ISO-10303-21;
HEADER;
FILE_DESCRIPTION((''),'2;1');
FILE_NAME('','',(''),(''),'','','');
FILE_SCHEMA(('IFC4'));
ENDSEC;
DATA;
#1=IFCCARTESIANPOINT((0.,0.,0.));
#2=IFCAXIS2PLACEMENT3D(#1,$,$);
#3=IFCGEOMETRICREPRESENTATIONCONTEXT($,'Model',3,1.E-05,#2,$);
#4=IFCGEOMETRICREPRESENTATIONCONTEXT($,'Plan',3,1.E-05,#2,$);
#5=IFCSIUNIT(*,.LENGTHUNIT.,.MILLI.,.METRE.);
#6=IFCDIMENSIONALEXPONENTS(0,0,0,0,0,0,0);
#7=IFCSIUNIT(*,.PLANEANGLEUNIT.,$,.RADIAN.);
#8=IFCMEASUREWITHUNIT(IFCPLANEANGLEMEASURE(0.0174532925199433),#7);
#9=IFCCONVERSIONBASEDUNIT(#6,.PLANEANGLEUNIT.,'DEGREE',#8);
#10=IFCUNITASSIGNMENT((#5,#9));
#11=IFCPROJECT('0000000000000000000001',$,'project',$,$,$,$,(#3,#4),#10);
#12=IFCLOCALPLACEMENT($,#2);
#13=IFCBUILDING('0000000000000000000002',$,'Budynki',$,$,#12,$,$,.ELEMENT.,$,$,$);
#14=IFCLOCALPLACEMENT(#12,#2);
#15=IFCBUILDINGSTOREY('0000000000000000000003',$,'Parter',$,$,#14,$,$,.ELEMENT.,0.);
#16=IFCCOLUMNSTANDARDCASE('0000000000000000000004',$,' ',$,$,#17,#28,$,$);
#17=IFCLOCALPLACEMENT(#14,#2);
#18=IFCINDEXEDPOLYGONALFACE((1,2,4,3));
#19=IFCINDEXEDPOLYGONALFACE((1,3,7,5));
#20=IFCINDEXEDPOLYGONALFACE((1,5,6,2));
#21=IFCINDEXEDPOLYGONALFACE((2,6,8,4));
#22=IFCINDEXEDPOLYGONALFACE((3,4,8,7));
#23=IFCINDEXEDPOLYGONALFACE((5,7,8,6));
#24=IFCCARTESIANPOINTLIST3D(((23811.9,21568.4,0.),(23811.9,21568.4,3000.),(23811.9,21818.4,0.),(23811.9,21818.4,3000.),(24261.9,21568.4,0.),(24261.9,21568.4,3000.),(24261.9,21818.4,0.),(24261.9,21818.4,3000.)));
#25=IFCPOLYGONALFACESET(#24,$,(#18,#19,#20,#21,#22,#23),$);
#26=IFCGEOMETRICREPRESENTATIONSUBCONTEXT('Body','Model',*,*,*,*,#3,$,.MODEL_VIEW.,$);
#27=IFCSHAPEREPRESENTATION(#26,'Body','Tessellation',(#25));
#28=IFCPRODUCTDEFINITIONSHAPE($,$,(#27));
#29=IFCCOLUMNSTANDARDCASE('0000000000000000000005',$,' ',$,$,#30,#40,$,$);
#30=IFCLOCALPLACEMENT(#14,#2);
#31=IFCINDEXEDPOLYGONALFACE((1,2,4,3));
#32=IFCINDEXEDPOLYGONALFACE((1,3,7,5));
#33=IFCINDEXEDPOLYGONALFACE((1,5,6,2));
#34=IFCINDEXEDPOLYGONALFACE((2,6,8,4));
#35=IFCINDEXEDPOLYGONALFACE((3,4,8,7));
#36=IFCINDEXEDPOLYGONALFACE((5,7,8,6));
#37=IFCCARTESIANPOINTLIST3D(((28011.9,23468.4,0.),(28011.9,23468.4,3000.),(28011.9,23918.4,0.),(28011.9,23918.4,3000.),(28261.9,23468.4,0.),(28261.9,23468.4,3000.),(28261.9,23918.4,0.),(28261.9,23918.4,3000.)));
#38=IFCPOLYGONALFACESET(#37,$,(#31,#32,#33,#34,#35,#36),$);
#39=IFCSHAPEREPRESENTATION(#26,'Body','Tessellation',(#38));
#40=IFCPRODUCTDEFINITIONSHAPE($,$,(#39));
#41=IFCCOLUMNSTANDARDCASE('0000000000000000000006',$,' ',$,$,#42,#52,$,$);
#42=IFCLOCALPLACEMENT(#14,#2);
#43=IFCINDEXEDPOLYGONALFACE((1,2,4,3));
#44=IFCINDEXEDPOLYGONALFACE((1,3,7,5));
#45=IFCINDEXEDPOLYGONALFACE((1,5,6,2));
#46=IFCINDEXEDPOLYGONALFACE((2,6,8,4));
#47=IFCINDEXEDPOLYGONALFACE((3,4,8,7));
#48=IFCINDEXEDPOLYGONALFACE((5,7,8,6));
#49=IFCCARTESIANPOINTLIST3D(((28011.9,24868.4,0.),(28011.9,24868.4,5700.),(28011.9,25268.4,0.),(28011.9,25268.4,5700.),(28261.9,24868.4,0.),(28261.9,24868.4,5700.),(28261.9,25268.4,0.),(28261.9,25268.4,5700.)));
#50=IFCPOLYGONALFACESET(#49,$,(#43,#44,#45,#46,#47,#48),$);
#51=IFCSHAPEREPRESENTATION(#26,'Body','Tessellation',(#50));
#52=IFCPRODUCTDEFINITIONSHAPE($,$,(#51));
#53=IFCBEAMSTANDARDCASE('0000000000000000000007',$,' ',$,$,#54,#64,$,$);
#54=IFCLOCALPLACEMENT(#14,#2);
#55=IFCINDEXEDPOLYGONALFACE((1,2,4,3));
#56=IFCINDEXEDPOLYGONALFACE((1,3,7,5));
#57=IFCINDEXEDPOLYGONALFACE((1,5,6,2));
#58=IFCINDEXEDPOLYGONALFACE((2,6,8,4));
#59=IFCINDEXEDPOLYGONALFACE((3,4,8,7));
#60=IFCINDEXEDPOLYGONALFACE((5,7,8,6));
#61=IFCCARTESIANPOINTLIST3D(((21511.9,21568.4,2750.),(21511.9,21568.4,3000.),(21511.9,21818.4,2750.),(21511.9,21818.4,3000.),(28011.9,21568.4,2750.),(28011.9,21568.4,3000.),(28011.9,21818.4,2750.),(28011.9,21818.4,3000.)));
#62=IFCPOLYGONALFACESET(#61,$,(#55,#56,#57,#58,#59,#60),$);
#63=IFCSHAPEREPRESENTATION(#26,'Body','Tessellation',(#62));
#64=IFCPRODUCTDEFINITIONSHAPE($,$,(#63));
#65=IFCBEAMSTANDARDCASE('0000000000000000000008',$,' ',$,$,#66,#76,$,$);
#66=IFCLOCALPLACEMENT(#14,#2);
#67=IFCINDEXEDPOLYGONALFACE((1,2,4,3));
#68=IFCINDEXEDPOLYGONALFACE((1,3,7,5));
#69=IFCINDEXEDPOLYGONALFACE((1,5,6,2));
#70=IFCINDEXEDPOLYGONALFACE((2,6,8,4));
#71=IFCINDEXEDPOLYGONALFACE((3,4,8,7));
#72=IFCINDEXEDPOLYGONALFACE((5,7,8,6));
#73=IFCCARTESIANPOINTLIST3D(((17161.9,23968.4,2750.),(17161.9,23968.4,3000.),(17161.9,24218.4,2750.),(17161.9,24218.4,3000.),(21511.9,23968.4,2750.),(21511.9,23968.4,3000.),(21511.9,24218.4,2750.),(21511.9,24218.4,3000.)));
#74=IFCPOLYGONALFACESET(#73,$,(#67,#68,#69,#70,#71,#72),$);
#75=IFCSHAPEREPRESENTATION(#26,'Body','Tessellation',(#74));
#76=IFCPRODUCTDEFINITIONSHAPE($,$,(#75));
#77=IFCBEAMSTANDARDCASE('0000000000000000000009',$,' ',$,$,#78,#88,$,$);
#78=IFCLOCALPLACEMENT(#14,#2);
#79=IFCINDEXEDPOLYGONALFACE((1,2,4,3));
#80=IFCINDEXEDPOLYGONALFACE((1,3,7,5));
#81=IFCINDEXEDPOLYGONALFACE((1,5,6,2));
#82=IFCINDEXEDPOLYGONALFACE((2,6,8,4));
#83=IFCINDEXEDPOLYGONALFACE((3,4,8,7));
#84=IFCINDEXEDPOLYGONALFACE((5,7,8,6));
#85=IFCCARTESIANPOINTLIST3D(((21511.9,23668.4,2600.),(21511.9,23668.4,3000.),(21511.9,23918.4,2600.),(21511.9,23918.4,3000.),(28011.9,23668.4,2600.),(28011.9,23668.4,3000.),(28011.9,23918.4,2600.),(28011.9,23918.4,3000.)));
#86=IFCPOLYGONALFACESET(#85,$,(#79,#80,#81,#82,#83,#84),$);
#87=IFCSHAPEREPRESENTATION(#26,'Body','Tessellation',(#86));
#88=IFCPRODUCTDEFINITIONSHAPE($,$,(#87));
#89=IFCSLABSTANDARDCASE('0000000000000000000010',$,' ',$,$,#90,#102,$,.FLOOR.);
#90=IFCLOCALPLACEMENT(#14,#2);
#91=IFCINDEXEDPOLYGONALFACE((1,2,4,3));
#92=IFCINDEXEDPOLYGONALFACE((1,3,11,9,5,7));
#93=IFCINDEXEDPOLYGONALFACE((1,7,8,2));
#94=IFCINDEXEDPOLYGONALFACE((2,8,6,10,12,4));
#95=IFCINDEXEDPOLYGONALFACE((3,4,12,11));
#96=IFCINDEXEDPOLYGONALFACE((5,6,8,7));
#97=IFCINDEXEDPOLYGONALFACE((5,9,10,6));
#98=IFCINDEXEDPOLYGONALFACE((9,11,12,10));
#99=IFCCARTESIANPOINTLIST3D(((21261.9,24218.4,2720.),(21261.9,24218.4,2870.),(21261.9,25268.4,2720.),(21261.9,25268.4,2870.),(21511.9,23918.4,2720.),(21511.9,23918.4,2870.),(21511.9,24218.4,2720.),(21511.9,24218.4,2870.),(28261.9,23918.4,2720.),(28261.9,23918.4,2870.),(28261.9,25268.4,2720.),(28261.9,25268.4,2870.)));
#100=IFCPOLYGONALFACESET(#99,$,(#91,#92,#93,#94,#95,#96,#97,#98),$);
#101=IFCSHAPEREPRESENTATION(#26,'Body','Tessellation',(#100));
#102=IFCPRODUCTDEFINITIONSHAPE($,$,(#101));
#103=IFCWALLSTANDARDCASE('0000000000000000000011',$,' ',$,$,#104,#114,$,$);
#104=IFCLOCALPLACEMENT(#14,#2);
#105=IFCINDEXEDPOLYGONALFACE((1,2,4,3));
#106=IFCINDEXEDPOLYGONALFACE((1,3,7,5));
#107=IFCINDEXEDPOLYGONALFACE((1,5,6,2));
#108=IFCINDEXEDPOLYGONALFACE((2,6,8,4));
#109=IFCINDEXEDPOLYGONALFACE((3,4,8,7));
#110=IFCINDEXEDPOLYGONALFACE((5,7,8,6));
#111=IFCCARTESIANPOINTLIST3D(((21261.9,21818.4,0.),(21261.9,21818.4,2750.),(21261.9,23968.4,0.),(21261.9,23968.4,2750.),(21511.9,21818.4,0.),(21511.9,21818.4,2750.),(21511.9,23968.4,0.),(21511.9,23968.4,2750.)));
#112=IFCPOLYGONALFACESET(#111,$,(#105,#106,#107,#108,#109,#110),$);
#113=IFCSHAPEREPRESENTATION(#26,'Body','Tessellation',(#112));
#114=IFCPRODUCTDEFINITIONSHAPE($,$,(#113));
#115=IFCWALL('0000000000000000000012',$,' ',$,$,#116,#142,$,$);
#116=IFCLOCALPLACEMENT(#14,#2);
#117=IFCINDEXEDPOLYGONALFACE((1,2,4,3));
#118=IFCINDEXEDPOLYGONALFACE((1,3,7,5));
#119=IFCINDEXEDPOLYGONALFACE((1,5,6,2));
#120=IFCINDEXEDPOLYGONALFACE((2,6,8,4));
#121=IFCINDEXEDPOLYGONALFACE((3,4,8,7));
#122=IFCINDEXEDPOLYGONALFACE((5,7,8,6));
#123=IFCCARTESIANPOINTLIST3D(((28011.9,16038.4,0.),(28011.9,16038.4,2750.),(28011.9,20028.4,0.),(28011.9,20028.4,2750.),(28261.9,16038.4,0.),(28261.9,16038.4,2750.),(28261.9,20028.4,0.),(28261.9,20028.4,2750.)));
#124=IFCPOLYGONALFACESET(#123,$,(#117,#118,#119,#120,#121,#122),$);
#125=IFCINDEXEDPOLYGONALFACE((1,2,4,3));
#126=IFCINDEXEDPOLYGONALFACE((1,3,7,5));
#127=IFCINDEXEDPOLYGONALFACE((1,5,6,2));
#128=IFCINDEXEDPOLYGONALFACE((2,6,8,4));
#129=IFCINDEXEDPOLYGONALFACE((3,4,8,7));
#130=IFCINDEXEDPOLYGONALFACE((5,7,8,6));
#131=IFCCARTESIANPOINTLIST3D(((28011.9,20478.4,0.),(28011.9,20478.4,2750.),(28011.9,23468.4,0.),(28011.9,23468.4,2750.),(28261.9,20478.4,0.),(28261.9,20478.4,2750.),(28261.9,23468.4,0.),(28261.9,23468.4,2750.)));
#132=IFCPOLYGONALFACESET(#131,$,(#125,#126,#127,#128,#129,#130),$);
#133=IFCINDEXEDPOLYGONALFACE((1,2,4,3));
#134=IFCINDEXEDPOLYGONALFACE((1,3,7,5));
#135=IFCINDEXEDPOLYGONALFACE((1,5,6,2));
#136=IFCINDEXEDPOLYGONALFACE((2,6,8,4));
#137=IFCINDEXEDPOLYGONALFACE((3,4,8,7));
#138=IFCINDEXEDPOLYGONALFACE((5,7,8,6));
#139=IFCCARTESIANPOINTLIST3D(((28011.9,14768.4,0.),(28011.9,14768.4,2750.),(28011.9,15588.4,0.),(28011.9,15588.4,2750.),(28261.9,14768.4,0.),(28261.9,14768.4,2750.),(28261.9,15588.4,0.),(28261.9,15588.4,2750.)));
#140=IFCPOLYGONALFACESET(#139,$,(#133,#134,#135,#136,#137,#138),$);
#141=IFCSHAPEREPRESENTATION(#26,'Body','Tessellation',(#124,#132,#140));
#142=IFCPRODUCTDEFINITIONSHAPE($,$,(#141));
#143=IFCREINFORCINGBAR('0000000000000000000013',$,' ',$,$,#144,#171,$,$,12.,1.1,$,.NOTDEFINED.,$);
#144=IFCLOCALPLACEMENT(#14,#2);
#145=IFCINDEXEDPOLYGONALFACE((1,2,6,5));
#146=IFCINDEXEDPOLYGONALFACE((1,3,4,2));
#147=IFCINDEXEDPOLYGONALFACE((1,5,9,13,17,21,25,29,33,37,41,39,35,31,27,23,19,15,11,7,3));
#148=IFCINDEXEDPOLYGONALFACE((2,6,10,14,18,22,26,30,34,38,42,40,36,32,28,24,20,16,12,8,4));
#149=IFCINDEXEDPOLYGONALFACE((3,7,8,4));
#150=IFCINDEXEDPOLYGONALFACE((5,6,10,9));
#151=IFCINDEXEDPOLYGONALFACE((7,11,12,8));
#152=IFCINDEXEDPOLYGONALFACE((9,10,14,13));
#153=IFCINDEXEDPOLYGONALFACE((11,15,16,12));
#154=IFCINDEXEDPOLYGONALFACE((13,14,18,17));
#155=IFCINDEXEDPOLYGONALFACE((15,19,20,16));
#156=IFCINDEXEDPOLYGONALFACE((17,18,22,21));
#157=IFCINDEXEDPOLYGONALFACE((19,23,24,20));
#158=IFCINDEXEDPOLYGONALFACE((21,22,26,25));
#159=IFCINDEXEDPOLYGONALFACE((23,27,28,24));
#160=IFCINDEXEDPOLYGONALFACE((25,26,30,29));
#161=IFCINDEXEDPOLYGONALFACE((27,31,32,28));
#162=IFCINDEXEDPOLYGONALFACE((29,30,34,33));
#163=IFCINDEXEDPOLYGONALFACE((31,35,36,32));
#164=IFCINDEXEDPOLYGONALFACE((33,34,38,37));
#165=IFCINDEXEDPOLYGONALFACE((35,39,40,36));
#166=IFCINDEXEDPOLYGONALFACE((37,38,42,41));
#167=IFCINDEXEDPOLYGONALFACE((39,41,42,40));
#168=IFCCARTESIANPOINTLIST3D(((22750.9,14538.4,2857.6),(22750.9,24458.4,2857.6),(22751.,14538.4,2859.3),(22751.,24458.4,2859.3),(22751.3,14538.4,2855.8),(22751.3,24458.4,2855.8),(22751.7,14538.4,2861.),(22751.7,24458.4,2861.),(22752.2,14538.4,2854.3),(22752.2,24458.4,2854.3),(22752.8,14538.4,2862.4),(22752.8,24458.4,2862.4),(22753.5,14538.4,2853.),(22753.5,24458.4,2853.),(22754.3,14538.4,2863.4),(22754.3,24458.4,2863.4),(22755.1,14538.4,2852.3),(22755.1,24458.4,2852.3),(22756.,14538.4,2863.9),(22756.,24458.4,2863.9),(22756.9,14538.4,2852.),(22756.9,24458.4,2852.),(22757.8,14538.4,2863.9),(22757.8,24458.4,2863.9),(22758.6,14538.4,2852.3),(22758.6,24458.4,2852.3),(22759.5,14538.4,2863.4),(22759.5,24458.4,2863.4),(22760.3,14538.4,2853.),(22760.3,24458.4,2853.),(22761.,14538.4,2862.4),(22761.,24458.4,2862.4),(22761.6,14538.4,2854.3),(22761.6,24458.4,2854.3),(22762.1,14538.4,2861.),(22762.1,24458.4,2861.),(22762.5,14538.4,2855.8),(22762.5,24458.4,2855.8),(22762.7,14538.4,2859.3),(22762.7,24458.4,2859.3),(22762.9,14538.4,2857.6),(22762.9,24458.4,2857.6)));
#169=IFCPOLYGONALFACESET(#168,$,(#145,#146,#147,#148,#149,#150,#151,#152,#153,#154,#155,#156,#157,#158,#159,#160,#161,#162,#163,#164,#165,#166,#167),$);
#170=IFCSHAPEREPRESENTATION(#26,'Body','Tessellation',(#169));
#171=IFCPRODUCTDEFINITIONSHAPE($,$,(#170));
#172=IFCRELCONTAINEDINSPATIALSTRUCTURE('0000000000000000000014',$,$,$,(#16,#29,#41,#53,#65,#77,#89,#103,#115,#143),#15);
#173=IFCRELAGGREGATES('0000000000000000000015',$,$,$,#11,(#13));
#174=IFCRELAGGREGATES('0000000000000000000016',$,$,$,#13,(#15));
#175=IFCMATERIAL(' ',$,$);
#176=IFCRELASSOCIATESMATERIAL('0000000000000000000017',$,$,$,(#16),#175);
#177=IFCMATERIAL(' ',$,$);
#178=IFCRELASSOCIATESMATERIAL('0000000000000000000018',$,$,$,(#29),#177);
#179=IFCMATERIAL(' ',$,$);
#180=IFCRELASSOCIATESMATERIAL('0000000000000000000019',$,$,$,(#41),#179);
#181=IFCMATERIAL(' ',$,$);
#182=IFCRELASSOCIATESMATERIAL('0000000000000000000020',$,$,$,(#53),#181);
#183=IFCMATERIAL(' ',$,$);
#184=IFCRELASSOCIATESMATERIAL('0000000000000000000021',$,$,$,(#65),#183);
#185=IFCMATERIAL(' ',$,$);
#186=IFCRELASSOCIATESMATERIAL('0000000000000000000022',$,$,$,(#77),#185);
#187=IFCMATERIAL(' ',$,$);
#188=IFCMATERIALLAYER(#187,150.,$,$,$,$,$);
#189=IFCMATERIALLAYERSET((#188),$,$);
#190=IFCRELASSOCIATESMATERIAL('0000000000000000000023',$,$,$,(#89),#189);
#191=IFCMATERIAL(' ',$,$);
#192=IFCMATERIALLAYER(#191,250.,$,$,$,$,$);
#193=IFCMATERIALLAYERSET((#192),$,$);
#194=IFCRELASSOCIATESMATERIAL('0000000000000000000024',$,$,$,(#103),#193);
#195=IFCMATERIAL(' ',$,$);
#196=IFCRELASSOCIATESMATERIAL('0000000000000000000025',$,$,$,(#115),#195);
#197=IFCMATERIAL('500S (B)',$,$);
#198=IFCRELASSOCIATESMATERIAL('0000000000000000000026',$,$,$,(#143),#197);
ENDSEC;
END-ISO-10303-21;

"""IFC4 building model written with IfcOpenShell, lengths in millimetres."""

from ifc_helpers import new_model, entity, si_unit, converted_unit, frame, frame_2d, origin, origin_with_axes, place, context, subcontext, project, spatial, polyline, rectangle, outline, extrude, material, layer, layer_set, layer_usage, material_profile, profile_set, profile_usage, element, save


model = new_model("IFC4")

# Units and contexts
model_context = context("Model", 3, precision=1e-05, world=origin())
plan_context = context("Plan", 3, precision=1e-05, world=origin())
body_context = subcontext(model_context, "Body", "Model", "MODEL_VIEW")
ifc_project = project(units=[si_unit("LENGTHUNIT", "METRE", prefix="MILLI"), converted_unit("PLANEANGLEUNIT", "DEGREE", entity("IfcPlaneAngleMeasure", 0.0174532925199433), si_unit("PLANEANGLEUNIT", "RADIAN"), dimensions=[0, 0, 0, 0, 0, 0, 0])], contexts=[model_context, plan_context])

# Building, storey
building_placement = place(None, origin())
building = spatial("IfcBuilding", under=ifc_project, at=building_placement, Name="Budynki", CompositionType="ELEMENT")
storey_placement = place(building_placement, origin())
storey = spatial("IfcBuildingStorey", under=building, at=storey_placement, Name="Parter", CompositionType="ELEMENT", Elevation=0.0)

# Columns
ifc_material_1 = material(Name=" ")
ifc_material_profile_1 = material_profile(ifc_material_1, rectangle(XDim=450.0, YDim=250.0, at=frame_2d((-225.0, -125.0), x_axis=(-1.0, 0.0))))
ifc_profile_set_1 = profile_set([ifc_material_profile_1])
ifc_profile_usage_1 = profile_usage(ifc_profile_set_1)
column_1_placement = place(storey_placement, frame((23811.9, 21568.4, 0.0)))
element("IfcColumnStandardCase", 1, at=column_1_placement, inside=storey, material=ifc_profile_usage_1, Name=" ", context=body_context, shape_type="SweptSolid", body=[
    extrude(rectangle(XDim=450.0, YDim=250.0, at=frame_2d((-225.0, -125.0), x_axis=(-1.0, 0.0))), frame((450.0, 250.0, 0.0), z_axis=(0.0, 0.0, 1.0), x_axis=(1.0, 0.0, 0.0)), (0.0, 0.0, 1.0), 3000.0),
])
ifc_material_2 = material(Name=" ")
ifc_material_profile_2 = material_profile(ifc_material_2, rectangle(XDim=450.0, YDim=250.0, at=frame_2d((-125.0, 225.0), x_axis=(0.0, 1.0))))
ifc_profile_set_2 = profile_set([ifc_material_profile_2])
ifc_profile_usage_2 = profile_usage(ifc_profile_set_2)
column_2_placement = place(storey_placement, frame((28011.9, 23468.4, 0.0)))
element("IfcColumnStandardCase", 2, at=column_2_placement, inside=storey, material=ifc_profile_usage_2, Name=" ", context=body_context, shape_type="SweptSolid", body=[
    extrude(rectangle(XDim=450.0, YDim=250.0, at=frame_2d((-125.0, 225.0), x_axis=(0.0, 1.0))), frame((250.0, 0.0, 0.0), z_axis=(0.0, 0.0, 1.0), x_axis=(1.0, 0.0, 0.0)), (0.0, 0.0, 1.0), 3000.0),
])
ifc_material_3 = material(Name=" ")
ifc_material_profile_3 = material_profile(ifc_material_3, outline(polyline([(0.0, 0.0), (250.0, 0.0), (250.0, 400.0), (0.0, 400.0), (0.0, 0.0)])))
ifc_profile_set_3 = profile_set([ifc_material_profile_3])
ifc_profile_usage_3 = profile_usage(ifc_profile_set_3)
column_3_placement = place(storey_placement, frame((28011.9, 24868.4, 0.0)))
element("IfcColumnStandardCase", 3, at=column_3_placement, inside=storey, material=ifc_profile_usage_3, Name=" ", context=body_context, shape_type="SweptSolid", body=[
    extrude(outline(polyline([(0.0, 0.0), (250.0, 0.0), (250.0, 400.0), (0.0, 400.0), (0.0, 0.0)])), origin_with_axes(), (0.0, 0.0, 1.0), 5700.0),
])

# Beams
ifc_material_4 = material(Name=" ")
ifc_material_profile_4 = material_profile(ifc_material_4, rectangle(XDim=250.0, YDim=250.0, at=frame_2d((125.0, -125.0), x_axis=(0.0, 1.0))))
ifc_profile_set_4 = profile_set([ifc_material_profile_4])
ifc_profile_usage_4 = profile_usage(ifc_profile_set_4)
beam_1_placement = place(storey_placement, frame((28011.9, 21818.4, 2750.0), z_axis=(0.0, 0.0, 1.0), x_axis=(-1.0, 0.0, 0.0)))
element("IfcBeamStandardCase", 4, at=beam_1_placement, inside=storey, material=ifc_profile_usage_4, Name=" ", context=body_context, shape_type="SweptSolid", body=[
    extrude(rectangle(XDim=250.0, YDim=250.0, at=frame_2d((125.0, -125.0), x_axis=(0.0, 1.0))), frame((0.0, 0.0, 0.0), z_axis=(1.0, 0.0, 0.0), x_axis=(0.0, 0.0, 1.0)), (0.0, 0.0, 1.0), 6500.0),
])
ifc_material_5 = material(Name=" ")
ifc_material_profile_5 = material_profile(ifc_material_5, rectangle(XDim=250.0, YDim=250.0, at=frame_2d((125.0, -125.0), x_axis=(0.0, 1.0))))
ifc_profile_set_5 = profile_set([ifc_material_profile_5])
ifc_profile_usage_5 = profile_usage(ifc_profile_set_5)
beam_2_placement = place(storey_placement, frame((21511.9, 24218.4, 2750.0), z_axis=(0.0, 0.0, 1.0), x_axis=(-1.0, 0.0, 0.0)))
element("IfcBeamStandardCase", 5, at=beam_2_placement, inside=storey, material=ifc_profile_usage_5, Name=" ", context=body_context, shape_type="SweptSolid", body=[
    extrude(rectangle(XDim=250.0, YDim=250.0, at=frame_2d((125.0, -125.0), x_axis=(0.0, 1.0))), frame((0.0, 0.0, 0.0), z_axis=(1.0, 0.0, 0.0), x_axis=(0.0, 0.0, 1.0)), (0.0, 0.0, 1.0), 4350.0),
])
ifc_material_6 = material(Name=" ")
ifc_material_profile_6 = material_profile(ifc_material_6, rectangle(XDim=250.0, YDim=400.0, at=frame_2d((200.0, -125.0), x_axis=(0.0, 1.0))))
ifc_profile_set_6 = profile_set([ifc_material_profile_6])
ifc_profile_usage_6 = profile_usage(ifc_profile_set_6)
beam_3_placement = place(storey_placement, frame((28011.9, 23918.4, 2600.0), z_axis=(0.0, 0.0, 1.0), x_axis=(-1.0, 0.0, 0.0)))
element("IfcBeamStandardCase", 6, at=beam_3_placement, inside=storey, material=ifc_profile_usage_6, Name=" ", context=body_context, shape_type="SweptSolid", body=[
    extrude(rectangle(XDim=250.0, YDim=400.0, at=frame_2d((200.0, -125.0), x_axis=(0.0, 1.0))), frame((0.0, 0.0, 0.0), z_axis=(1.0, 0.0, 0.0), x_axis=(0.0, 0.0, 1.0)), (0.0, 0.0, 1.0), 6500.0),
])

# Slab
ifc_material_7 = material(Name=" ")
ifc_layer_1 = layer(ifc_material_7, 150.0)
ifc_layer_set_1 = layer_set([ifc_layer_1])
ifc_layer_usage_1 = layer_usage(ifc_layer_set_1, "AXIS3", "POSITIVE", 0.0)
slab_placement = place(storey_placement, frame((21261.9, 23918.4, 2720.0)))
element("IfcSlabStandardCase", 7, at=slab_placement, inside=storey, material=ifc_layer_usage_1, Name=" ", PredefinedType="FLOOR", context=body_context, shape_type="SweptSolid", body=[
    extrude(outline(polyline([(7000.0, 0.0), (7000.0, 1350.0), (0.0, 1350.0), (0.0, 300.0), (250.0, 300.0), (250.0, 0.0), (7000.0, 0.0)])), origin_with_axes(), (0.0, 0.0, 1.0), 150.0),
])

# Walls
ifc_material_8 = material(Name=" ")
ifc_layer_2 = layer(ifc_material_8, 250.0)
ifc_layer_set_2 = layer_set([ifc_layer_2])
ifc_layer_usage_2 = layer_usage(ifc_layer_set_2, "AXIS2", "POSITIVE", 0.0)
wall_1_placement = place(storey_placement, frame((21261.9, 23968.4, 0.0), z_axis=(0.0, 0.0, 1.0), x_axis=(0.0, -1.0, 0.0)))
element("IfcWallStandardCase", 8, at=wall_1_placement, inside=storey, material=ifc_layer_usage_2, Name=" ", context=body_context, shape_type="SweptSolid", body=[
    extrude(rectangle(XDim=2150.0, YDim=250.0, at=frame_2d((1075.0, 125.0), x_axis=(1.0, 0.0))), origin_with_axes(), (0.0, 0.0, 1.0), 2750.0),
])
ifc_material_9 = material(Name=" ")
wall_2_placement = place(storey_placement, frame((28011.9, 23468.4, 0.0), z_axis=(0.0, 0.0, 1.0), x_axis=(0.0, -1.0, 0.0)))
element("IfcWall", 9, at=wall_2_placement, inside=storey, material=ifc_material_9, Name=" ", context=body_context, shape_type="SweptSolid", body=[
    extrude(rectangle(XDim=250.0, YDim=3990.0, at=frame_2d((1995.0, -125.0), x_axis=(0.0, -1.0))), frame((3440.0, 250.0, 0.0), z_axis=(0.0, 0.0, 1.0), x_axis=(1.0, 0.0, 0.0)), (0.0, 0.0, 1.0), 2750.0),
    extrude(rectangle(XDim=2990.0, YDim=250.0, at=frame_2d((1495.0, 125.0), x_axis=(1.0, 0.0))), origin_with_axes(), (0.0, 0.0, 1.0), 2750.0),
    extrude(rectangle(XDim=820.0, YDim=250.0, at=frame_2d((410.0, 125.0), x_axis=(1.0, 0.0))), frame((7880.0, 0.0, 0.0), z_axis=(0.0, 0.0, 1.0), x_axis=(1.0, 0.0, 0.0)), (0.0, 0.0, 1.0), 2750.0),
])

# Reinforcing bar
ifc_material_10 = material(Name="500S (B)")
reinforcing_bar_1_placement = place(storey_placement, frame((22756.9, 24458.4, 2858.0)))
element("IfcReinforcingBar", 10, at=reinforcing_bar_1_placement, inside=storey, material=ifc_material_10, Name=" ", CrossSectionArea=1.1, NominalDiameter=12.0, PredefinedType="NOTDEFINED", context=body_context, shape_type="AdvancedSweptSolid", body=[
    entity("IfcSweptDiskSolid", entity("IfcPolyline", [entity("IfcCartesianPoint", [0.0, 0.0, 0.0]), entity("IfcCartesianPoint", [0.0, -9920.0, 0.0])]), 6.0, None, 0.0, 1.0),
])

save(model, "model.ifc")
